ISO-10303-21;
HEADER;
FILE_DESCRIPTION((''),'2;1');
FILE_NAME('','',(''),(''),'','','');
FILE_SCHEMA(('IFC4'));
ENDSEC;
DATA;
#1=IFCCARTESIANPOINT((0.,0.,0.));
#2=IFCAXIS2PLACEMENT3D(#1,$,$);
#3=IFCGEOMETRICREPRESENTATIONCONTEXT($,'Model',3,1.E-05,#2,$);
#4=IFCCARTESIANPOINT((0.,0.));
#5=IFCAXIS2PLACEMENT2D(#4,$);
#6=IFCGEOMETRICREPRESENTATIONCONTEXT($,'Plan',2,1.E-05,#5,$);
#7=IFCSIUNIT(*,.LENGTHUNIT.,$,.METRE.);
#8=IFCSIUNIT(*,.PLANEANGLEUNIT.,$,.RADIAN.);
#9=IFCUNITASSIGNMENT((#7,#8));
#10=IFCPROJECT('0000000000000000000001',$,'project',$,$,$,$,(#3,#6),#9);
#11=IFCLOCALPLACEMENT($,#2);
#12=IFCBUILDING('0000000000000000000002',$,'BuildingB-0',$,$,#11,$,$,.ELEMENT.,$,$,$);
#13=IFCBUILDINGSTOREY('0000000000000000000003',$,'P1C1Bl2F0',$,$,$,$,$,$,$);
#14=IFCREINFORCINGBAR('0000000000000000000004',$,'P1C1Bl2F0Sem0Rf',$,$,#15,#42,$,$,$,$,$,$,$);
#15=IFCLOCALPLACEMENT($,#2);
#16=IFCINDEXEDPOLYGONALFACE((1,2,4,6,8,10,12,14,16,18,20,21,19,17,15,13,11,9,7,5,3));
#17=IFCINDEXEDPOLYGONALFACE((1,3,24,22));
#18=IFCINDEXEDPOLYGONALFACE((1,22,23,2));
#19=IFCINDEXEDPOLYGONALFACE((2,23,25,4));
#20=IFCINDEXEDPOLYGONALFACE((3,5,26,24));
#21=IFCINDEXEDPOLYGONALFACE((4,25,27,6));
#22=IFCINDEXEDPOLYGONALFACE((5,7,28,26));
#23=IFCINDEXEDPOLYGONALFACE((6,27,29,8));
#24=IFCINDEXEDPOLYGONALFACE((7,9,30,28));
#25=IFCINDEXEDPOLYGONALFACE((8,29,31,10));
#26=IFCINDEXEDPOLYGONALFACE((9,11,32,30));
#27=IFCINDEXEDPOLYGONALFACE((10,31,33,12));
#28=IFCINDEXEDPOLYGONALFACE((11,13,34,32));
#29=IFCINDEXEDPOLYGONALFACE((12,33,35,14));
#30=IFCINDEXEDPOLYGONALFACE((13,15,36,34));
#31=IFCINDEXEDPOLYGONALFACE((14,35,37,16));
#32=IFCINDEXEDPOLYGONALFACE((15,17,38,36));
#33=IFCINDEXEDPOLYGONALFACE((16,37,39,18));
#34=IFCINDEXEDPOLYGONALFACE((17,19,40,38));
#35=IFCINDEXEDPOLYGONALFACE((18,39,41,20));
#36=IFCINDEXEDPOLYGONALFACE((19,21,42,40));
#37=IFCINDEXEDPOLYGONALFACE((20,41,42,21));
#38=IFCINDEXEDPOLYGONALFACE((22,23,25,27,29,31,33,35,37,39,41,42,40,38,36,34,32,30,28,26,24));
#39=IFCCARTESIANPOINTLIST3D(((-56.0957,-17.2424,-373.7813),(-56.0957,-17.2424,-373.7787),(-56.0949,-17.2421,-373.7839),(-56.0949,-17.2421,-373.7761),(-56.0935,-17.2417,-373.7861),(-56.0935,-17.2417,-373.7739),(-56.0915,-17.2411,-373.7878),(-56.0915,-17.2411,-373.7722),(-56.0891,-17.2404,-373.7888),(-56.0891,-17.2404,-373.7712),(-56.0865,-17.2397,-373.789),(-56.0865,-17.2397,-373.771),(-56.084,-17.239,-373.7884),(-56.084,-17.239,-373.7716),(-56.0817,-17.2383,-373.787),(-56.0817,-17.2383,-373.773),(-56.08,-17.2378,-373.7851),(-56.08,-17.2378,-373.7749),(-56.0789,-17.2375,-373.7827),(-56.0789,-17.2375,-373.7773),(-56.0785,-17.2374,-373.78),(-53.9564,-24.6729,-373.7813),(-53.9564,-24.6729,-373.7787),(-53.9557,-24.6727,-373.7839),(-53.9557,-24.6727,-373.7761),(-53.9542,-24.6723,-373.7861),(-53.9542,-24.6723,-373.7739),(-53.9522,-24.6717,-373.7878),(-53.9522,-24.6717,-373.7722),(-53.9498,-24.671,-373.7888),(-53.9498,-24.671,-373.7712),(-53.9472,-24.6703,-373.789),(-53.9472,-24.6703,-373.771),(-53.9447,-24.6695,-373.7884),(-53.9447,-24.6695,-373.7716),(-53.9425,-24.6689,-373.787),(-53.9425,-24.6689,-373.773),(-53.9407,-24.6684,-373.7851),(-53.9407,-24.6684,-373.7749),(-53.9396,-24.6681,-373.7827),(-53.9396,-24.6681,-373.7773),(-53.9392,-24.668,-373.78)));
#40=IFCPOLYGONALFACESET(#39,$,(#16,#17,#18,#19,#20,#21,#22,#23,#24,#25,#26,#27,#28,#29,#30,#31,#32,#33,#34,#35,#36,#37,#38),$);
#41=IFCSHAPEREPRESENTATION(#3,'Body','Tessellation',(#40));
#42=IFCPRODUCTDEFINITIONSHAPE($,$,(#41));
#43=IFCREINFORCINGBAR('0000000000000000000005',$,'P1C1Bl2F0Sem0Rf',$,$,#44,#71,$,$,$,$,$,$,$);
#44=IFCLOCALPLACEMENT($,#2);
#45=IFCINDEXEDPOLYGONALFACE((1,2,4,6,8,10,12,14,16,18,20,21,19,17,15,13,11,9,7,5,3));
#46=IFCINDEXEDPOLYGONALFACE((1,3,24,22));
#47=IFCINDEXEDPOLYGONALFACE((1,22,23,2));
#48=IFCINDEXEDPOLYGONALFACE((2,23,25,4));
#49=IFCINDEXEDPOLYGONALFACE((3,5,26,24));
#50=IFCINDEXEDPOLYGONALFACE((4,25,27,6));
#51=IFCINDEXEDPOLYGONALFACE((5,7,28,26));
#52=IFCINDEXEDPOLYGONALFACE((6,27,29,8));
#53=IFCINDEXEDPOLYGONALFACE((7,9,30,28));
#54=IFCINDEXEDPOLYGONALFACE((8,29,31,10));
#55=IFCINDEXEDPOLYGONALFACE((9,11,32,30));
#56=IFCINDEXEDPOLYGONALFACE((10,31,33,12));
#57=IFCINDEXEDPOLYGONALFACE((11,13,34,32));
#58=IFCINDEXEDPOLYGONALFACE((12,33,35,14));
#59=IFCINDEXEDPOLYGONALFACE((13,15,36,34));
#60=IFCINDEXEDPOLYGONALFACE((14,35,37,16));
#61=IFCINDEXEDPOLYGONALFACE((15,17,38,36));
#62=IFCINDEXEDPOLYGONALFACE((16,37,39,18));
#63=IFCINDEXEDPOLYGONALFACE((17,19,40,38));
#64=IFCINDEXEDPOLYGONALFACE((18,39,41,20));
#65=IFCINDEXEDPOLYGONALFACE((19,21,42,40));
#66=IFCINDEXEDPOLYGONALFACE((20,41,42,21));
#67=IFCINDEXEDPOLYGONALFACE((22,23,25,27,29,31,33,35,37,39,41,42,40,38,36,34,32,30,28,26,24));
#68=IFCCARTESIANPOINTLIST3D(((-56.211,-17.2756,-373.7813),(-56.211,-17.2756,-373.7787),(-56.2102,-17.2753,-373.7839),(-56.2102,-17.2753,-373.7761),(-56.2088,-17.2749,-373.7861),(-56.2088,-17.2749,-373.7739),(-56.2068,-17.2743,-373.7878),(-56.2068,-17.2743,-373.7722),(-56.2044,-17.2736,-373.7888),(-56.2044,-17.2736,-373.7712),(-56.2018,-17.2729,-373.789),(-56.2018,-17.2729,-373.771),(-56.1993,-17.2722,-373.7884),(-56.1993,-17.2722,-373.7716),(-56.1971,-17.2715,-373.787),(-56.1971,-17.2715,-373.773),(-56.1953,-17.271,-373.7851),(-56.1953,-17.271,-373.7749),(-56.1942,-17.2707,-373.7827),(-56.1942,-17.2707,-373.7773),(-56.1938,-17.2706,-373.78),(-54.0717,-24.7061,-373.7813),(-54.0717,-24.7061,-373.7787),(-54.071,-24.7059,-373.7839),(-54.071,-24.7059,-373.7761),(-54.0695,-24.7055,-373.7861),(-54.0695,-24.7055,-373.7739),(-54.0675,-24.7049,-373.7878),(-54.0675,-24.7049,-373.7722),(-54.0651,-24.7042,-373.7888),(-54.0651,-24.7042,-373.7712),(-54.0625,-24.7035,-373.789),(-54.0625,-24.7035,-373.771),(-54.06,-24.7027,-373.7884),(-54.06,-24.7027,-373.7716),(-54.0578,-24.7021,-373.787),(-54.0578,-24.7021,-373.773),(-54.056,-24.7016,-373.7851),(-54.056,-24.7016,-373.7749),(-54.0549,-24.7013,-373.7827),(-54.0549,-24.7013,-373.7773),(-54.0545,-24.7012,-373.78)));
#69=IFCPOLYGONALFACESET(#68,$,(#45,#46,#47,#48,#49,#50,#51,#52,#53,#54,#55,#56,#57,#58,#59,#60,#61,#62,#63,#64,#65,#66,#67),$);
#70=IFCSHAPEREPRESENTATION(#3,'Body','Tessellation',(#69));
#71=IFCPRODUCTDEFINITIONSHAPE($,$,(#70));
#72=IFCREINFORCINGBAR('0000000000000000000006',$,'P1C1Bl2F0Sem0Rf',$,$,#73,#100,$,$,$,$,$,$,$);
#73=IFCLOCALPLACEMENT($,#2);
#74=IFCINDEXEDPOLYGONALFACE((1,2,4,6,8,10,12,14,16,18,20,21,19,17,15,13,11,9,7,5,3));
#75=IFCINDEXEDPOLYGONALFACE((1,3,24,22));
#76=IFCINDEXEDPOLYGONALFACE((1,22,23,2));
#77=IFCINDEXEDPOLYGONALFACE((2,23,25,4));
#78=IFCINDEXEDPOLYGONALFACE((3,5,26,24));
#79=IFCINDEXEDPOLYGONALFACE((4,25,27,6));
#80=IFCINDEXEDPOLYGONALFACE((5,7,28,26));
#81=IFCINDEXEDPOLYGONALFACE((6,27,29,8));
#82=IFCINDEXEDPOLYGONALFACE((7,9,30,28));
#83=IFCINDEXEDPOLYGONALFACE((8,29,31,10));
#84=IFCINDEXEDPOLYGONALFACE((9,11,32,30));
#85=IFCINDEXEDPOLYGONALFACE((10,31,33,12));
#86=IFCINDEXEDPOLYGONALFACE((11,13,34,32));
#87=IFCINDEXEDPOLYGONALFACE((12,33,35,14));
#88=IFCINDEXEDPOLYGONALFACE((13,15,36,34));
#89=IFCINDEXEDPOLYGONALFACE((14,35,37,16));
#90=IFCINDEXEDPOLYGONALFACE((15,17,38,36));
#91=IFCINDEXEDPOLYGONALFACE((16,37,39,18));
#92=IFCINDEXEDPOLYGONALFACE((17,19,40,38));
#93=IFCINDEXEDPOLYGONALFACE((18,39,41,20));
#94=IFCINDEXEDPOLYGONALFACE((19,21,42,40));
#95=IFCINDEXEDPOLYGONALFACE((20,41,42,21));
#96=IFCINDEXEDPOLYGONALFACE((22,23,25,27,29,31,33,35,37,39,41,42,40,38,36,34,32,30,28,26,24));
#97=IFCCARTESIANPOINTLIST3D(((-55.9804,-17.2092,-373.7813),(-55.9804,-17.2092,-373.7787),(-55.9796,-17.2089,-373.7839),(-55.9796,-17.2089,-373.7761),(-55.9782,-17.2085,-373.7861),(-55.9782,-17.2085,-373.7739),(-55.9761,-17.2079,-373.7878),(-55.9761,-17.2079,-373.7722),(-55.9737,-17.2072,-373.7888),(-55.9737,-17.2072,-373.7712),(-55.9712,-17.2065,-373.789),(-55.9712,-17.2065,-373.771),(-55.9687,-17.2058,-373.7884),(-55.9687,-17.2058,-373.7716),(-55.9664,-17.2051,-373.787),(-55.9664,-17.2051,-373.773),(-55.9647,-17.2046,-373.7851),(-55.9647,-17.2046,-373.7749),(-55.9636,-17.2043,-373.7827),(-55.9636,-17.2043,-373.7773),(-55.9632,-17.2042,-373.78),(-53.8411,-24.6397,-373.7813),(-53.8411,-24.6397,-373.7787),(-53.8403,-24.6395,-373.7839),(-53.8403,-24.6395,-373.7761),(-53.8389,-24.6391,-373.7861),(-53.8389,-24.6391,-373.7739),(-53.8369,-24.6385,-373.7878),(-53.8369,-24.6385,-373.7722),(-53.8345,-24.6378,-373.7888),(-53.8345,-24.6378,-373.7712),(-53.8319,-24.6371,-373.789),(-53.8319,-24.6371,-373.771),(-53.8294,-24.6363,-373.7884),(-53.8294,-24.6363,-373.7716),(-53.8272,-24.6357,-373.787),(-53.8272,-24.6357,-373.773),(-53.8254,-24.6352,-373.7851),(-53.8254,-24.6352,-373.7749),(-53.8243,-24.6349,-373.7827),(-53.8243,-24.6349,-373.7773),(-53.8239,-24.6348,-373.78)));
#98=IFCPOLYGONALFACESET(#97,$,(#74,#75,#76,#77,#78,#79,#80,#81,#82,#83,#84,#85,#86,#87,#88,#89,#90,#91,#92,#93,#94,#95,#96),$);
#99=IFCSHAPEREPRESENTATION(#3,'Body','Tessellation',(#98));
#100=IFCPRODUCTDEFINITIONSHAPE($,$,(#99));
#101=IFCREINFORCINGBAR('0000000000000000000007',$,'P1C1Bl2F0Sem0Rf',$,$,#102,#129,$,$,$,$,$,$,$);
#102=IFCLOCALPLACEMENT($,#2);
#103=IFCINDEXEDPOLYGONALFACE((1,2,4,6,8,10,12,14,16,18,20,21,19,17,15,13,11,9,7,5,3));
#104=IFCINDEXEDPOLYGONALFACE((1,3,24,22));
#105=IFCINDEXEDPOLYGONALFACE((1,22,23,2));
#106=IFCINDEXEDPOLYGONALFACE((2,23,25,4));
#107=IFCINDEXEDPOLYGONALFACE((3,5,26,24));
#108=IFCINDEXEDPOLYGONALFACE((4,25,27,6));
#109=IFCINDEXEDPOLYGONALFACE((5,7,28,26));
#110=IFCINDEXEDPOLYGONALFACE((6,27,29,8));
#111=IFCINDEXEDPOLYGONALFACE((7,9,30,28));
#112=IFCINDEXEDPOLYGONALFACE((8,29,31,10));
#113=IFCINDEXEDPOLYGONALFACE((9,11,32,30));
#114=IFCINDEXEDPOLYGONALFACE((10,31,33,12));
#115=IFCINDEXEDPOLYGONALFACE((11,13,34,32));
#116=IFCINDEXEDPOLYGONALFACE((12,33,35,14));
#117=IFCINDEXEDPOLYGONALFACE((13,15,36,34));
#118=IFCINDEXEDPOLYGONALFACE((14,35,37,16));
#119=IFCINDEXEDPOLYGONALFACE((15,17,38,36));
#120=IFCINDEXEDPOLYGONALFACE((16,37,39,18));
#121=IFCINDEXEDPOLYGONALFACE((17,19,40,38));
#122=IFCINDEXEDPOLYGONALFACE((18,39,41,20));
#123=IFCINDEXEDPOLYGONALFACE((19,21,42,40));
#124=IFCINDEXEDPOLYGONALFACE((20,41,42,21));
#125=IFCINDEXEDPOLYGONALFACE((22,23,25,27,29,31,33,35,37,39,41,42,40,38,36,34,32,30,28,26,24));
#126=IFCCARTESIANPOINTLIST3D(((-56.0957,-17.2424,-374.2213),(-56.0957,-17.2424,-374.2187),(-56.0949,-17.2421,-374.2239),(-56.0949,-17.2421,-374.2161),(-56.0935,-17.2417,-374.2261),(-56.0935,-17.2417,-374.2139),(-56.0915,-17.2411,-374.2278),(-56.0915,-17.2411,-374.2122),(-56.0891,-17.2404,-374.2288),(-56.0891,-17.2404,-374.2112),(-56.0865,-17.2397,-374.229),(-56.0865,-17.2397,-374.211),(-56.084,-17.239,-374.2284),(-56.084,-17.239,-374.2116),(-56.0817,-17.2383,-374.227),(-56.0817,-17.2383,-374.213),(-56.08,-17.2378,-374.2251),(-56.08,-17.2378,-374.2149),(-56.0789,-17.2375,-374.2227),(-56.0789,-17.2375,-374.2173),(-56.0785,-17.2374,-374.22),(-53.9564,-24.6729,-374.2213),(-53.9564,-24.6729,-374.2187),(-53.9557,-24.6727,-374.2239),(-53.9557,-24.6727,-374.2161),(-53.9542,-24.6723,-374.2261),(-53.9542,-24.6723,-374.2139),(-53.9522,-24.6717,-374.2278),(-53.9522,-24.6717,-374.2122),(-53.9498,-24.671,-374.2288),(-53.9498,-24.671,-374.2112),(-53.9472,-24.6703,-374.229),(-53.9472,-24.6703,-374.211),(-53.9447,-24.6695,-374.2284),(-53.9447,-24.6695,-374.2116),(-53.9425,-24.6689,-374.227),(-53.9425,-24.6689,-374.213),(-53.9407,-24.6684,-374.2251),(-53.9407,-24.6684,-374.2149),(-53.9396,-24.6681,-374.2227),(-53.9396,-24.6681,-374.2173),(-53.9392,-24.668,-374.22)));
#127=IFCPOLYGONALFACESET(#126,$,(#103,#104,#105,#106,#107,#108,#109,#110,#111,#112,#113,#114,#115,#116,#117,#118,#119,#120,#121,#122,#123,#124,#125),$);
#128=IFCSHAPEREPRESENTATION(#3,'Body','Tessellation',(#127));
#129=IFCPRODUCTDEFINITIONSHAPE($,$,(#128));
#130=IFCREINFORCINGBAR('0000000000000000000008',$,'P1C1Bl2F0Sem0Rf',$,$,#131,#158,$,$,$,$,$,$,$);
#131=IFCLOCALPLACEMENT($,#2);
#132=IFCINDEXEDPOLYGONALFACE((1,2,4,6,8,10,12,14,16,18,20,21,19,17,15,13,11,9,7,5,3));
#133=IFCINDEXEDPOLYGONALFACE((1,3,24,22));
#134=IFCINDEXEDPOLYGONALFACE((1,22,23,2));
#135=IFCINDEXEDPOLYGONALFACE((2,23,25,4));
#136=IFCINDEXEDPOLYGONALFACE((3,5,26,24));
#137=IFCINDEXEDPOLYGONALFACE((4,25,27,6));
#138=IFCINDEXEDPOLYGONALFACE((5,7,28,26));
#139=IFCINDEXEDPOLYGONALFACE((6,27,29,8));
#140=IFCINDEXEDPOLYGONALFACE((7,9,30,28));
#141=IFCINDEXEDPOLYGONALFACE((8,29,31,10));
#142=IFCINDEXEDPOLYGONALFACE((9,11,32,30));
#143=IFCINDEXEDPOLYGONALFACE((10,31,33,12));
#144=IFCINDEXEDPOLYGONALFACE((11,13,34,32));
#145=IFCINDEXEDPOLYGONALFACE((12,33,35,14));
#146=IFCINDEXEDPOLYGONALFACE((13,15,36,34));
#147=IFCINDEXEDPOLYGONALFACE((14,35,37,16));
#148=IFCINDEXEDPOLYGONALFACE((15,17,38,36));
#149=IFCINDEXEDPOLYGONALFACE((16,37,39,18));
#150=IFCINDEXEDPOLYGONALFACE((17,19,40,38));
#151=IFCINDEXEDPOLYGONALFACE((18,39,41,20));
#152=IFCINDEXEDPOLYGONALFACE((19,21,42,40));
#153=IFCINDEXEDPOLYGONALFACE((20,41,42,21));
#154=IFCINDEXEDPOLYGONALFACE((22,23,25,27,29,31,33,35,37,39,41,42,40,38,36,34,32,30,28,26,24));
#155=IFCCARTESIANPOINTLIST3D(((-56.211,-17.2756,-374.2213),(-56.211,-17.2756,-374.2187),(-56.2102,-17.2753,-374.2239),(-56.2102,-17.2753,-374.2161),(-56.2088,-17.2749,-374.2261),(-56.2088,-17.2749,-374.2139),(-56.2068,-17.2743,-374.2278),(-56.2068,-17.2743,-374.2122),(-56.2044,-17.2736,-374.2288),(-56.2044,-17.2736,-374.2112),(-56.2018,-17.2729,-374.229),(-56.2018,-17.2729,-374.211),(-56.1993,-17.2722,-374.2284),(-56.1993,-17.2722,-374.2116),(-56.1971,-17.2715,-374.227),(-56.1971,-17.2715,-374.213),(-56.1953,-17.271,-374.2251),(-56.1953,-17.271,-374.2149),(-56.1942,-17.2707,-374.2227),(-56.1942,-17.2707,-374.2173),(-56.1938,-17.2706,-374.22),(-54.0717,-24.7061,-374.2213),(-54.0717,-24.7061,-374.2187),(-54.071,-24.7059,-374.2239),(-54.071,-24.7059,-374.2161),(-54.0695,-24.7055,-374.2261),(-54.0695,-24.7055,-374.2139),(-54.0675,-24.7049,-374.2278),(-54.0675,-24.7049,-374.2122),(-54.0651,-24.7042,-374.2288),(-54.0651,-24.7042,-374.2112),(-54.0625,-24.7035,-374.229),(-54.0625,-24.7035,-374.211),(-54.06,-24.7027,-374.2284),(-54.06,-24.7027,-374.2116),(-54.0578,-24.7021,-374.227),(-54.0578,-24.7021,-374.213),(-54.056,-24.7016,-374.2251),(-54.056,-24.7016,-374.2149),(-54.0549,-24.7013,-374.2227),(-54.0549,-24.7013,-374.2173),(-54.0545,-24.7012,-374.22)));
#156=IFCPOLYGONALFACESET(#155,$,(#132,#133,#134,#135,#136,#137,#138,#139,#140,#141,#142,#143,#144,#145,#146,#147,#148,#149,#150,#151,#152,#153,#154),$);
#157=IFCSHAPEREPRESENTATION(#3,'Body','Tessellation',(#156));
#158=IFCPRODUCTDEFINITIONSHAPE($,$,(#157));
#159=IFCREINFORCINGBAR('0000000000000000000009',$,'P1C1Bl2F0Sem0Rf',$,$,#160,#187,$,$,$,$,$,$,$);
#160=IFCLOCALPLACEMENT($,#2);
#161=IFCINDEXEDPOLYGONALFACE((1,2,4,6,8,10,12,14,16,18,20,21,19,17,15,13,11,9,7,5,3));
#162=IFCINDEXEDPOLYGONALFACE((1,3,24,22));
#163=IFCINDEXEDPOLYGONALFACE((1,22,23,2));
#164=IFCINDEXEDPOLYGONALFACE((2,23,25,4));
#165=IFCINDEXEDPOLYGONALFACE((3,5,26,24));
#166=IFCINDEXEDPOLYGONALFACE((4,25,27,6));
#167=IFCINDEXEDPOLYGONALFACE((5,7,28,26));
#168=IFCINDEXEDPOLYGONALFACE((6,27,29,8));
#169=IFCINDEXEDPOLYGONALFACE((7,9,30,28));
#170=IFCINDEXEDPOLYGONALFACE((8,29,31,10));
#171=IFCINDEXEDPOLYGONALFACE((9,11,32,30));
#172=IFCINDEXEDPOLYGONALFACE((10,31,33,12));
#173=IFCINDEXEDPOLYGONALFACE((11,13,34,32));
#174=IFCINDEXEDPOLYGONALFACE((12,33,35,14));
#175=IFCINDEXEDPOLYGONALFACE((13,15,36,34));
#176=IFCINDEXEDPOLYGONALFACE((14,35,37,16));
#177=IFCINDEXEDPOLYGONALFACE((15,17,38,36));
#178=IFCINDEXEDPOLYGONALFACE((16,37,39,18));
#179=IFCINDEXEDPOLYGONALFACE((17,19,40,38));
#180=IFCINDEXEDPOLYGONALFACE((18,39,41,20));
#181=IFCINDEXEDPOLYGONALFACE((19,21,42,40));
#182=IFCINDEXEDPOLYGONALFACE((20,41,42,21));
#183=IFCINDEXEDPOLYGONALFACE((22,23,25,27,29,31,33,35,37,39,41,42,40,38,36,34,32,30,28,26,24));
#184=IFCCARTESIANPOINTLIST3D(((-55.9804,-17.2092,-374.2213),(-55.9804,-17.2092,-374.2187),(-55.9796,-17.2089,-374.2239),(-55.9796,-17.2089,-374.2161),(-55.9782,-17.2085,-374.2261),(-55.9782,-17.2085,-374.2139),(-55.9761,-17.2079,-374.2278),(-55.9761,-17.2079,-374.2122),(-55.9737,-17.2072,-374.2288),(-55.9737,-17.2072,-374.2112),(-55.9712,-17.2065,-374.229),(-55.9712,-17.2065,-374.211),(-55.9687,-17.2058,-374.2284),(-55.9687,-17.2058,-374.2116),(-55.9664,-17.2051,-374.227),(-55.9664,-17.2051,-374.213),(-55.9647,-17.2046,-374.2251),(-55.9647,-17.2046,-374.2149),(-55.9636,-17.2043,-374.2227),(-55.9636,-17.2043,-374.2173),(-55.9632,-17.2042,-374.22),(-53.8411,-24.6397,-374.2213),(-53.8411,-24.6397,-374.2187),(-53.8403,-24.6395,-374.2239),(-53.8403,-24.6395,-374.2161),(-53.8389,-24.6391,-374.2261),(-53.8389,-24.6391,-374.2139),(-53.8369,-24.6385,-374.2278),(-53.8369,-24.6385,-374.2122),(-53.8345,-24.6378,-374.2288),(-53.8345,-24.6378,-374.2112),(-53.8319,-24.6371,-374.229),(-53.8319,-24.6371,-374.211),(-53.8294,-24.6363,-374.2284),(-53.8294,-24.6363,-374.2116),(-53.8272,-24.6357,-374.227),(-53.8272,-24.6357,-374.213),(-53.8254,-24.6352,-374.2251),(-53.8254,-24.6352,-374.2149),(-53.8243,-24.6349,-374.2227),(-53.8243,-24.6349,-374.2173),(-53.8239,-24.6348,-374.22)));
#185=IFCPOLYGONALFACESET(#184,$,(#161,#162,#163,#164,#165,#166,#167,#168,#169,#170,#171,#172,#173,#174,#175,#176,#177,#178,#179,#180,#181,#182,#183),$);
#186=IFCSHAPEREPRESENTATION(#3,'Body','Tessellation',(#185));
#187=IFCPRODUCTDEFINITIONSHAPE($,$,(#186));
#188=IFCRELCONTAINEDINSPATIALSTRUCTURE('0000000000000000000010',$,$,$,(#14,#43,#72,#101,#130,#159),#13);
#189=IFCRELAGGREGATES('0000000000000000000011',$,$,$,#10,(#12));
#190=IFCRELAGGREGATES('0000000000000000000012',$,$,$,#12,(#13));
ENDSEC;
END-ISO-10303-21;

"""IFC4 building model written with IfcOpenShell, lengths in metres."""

from ifc_helpers import new_model, entity, si_unit, origin, origin_2d, place, context, project, spatial, element, save


model = new_model("IFC4")

# Units and contexts
model_context = context("Model", 3, precision=1e-05, world=origin())
plan_context = context("Plan", 2, precision=1e-05, world=origin_2d())
ifc_project = project(units=[si_unit("LENGTHUNIT", "METRE"), si_unit("PLANEANGLEUNIT", "RADIAN")], contexts=[model_context, plan_context])

# Building, storey
building_placement = place(None, origin())
building = spatial("IfcBuilding", under=ifc_project, at=building_placement, Name="BuildingB-0", CompositionType="ELEMENT")
storey = spatial("IfcBuildingStorey", under=building, Name="P1C1Bl2F0")

# Reinforcing bars
element("IfcReinforcingBar", 1, inside=storey, Name="P1C1Bl2F0Sem0Rf", context=model_context, shape_type="SweptSolid", body=[
    entity("IfcSurfaceCurveSweptAreaSolid", entity("IfcCircleProfileDef", "AREA", None, None, 0.009), None, entity("IfcPolyline", [entity("IfcCartesianPoint", [56.0871, 17.2399, 373.78]), entity("IfcCartesianPoint", [53.9479, 24.6704, 373.78])]), None, None, entity("IfcPlane", entity("IfcAxis2Placement3D", entity("IfcCartesianPoint", [56.0871, 17.2399, 373.78]), entity("IfcDirection", [0.0, 0.0, 1.0]), entity("IfcDirection", [1.0, 0.0, 0.0])))),
])
element("IfcReinforcingBar", 2, inside=storey, Name="P1C1Bl2F0Sem0Rf", context=model_context, shape_type="SweptSolid", body=[
    entity("IfcSurfaceCurveSweptAreaSolid", entity("IfcCircleProfileDef", "AREA", None, None, 0.009), None, entity("IfcPolyline", [entity("IfcCartesianPoint", [56.2024, 17.2731, 373.78]), entity("IfcCartesianPoint", [54.0632, 24.7036, 373.78])]), None, None, entity("IfcPlane", entity("IfcAxis2Placement3D", entity("IfcCartesianPoint", [56.2024, 17.2731, 373.78]), entity("IfcDirection", [0.0, 0.0, 1.0]), entity("IfcDirection", [1.0, 0.0, 0.0])))),
])
element("IfcReinforcingBar", 3, inside=storey, Name="P1C1Bl2F0Sem0Rf", context=model_context, shape_type="SweptSolid", body=[
    entity("IfcSurfaceCurveSweptAreaSolid", entity("IfcCircleProfileDef", "AREA", None, None, 0.009), None, entity("IfcPolyline", [entity("IfcCartesianPoint", [55.9718, 17.2067, 373.78]), entity("IfcCartesianPoint", [53.8326, 24.6372, 373.78])]), None, None, entity("IfcPlane", entity("IfcAxis2Placement3D", entity("IfcCartesianPoint", [55.9718, 17.2067, 373.78]), entity("IfcDirection", [0.0, 0.0, 1.0]), entity("IfcDirection", [1.0, 0.0, 0.0])))),
])
element("IfcReinforcingBar", 4, inside=storey, Name="P1C1Bl2F0Sem0Rf", context=model_context, shape_type="SweptSolid", body=[
    entity("IfcSurfaceCurveSweptAreaSolid", entity("IfcCircleProfileDef", "AREA", None, None, 0.009), None, entity("IfcPolyline", [entity("IfcCartesianPoint", [56.0871, 17.2399, 374.22]), entity("IfcCartesianPoint", [53.9479, 24.6704, 374.22])]), None, None, entity("IfcPlane", entity("IfcAxis2Placement3D", entity("IfcCartesianPoint", [56.0871, 17.2399, 374.22]), entity("IfcDirection", [0.0, 0.0, 1.0]), entity("IfcDirection", [1.0, 0.0, 0.0])))),
])
element("IfcReinforcingBar", 5, inside=storey, Name="P1C1Bl2F0Sem0Rf", context=model_context, shape_type="SweptSolid", body=[
    entity("IfcSurfaceCurveSweptAreaSolid", entity("IfcCircleProfileDef", "AREA", None, None, 0.009), None, entity("IfcPolyline", [entity("IfcCartesianPoint", [56.2024, 17.2731, 374.22]), entity("IfcCartesianPoint", [54.0632, 24.7036, 374.22])]), None, None, entity("IfcPlane", entity("IfcAxis2Placement3D", entity("IfcCartesianPoint", [56.2024, 17.2731, 374.22]), entity("IfcDirection", [0.0, 0.0, 1.0]), entity("IfcDirection", [1.0, 0.0, 0.0])))),
])
element("IfcReinforcingBar", 6, inside=storey, Name="P1C1Bl2F0Sem0Rf", context=model_context, shape_type="SweptSolid", body=[
    entity("IfcSurfaceCurveSweptAreaSolid", entity("IfcCircleProfileDef", "AREA", None, None, 0.009), None, entity("IfcPolyline", [entity("IfcCartesianPoint", [55.9718, 17.2067, 374.22]), entity("IfcCartesianPoint", [53.8326, 24.6372, 374.22])]), None, None, entity("IfcPlane", entity("IfcAxis2Placement3D", entity("IfcCartesianPoint", [55.9718, 17.2067, 374.22]), entity("IfcDirection", [0.0, 0.0, 1.0]), entity("IfcDirection", [1.0, 0.0, 0.0])))),
])

save(model, "model.ifc")
